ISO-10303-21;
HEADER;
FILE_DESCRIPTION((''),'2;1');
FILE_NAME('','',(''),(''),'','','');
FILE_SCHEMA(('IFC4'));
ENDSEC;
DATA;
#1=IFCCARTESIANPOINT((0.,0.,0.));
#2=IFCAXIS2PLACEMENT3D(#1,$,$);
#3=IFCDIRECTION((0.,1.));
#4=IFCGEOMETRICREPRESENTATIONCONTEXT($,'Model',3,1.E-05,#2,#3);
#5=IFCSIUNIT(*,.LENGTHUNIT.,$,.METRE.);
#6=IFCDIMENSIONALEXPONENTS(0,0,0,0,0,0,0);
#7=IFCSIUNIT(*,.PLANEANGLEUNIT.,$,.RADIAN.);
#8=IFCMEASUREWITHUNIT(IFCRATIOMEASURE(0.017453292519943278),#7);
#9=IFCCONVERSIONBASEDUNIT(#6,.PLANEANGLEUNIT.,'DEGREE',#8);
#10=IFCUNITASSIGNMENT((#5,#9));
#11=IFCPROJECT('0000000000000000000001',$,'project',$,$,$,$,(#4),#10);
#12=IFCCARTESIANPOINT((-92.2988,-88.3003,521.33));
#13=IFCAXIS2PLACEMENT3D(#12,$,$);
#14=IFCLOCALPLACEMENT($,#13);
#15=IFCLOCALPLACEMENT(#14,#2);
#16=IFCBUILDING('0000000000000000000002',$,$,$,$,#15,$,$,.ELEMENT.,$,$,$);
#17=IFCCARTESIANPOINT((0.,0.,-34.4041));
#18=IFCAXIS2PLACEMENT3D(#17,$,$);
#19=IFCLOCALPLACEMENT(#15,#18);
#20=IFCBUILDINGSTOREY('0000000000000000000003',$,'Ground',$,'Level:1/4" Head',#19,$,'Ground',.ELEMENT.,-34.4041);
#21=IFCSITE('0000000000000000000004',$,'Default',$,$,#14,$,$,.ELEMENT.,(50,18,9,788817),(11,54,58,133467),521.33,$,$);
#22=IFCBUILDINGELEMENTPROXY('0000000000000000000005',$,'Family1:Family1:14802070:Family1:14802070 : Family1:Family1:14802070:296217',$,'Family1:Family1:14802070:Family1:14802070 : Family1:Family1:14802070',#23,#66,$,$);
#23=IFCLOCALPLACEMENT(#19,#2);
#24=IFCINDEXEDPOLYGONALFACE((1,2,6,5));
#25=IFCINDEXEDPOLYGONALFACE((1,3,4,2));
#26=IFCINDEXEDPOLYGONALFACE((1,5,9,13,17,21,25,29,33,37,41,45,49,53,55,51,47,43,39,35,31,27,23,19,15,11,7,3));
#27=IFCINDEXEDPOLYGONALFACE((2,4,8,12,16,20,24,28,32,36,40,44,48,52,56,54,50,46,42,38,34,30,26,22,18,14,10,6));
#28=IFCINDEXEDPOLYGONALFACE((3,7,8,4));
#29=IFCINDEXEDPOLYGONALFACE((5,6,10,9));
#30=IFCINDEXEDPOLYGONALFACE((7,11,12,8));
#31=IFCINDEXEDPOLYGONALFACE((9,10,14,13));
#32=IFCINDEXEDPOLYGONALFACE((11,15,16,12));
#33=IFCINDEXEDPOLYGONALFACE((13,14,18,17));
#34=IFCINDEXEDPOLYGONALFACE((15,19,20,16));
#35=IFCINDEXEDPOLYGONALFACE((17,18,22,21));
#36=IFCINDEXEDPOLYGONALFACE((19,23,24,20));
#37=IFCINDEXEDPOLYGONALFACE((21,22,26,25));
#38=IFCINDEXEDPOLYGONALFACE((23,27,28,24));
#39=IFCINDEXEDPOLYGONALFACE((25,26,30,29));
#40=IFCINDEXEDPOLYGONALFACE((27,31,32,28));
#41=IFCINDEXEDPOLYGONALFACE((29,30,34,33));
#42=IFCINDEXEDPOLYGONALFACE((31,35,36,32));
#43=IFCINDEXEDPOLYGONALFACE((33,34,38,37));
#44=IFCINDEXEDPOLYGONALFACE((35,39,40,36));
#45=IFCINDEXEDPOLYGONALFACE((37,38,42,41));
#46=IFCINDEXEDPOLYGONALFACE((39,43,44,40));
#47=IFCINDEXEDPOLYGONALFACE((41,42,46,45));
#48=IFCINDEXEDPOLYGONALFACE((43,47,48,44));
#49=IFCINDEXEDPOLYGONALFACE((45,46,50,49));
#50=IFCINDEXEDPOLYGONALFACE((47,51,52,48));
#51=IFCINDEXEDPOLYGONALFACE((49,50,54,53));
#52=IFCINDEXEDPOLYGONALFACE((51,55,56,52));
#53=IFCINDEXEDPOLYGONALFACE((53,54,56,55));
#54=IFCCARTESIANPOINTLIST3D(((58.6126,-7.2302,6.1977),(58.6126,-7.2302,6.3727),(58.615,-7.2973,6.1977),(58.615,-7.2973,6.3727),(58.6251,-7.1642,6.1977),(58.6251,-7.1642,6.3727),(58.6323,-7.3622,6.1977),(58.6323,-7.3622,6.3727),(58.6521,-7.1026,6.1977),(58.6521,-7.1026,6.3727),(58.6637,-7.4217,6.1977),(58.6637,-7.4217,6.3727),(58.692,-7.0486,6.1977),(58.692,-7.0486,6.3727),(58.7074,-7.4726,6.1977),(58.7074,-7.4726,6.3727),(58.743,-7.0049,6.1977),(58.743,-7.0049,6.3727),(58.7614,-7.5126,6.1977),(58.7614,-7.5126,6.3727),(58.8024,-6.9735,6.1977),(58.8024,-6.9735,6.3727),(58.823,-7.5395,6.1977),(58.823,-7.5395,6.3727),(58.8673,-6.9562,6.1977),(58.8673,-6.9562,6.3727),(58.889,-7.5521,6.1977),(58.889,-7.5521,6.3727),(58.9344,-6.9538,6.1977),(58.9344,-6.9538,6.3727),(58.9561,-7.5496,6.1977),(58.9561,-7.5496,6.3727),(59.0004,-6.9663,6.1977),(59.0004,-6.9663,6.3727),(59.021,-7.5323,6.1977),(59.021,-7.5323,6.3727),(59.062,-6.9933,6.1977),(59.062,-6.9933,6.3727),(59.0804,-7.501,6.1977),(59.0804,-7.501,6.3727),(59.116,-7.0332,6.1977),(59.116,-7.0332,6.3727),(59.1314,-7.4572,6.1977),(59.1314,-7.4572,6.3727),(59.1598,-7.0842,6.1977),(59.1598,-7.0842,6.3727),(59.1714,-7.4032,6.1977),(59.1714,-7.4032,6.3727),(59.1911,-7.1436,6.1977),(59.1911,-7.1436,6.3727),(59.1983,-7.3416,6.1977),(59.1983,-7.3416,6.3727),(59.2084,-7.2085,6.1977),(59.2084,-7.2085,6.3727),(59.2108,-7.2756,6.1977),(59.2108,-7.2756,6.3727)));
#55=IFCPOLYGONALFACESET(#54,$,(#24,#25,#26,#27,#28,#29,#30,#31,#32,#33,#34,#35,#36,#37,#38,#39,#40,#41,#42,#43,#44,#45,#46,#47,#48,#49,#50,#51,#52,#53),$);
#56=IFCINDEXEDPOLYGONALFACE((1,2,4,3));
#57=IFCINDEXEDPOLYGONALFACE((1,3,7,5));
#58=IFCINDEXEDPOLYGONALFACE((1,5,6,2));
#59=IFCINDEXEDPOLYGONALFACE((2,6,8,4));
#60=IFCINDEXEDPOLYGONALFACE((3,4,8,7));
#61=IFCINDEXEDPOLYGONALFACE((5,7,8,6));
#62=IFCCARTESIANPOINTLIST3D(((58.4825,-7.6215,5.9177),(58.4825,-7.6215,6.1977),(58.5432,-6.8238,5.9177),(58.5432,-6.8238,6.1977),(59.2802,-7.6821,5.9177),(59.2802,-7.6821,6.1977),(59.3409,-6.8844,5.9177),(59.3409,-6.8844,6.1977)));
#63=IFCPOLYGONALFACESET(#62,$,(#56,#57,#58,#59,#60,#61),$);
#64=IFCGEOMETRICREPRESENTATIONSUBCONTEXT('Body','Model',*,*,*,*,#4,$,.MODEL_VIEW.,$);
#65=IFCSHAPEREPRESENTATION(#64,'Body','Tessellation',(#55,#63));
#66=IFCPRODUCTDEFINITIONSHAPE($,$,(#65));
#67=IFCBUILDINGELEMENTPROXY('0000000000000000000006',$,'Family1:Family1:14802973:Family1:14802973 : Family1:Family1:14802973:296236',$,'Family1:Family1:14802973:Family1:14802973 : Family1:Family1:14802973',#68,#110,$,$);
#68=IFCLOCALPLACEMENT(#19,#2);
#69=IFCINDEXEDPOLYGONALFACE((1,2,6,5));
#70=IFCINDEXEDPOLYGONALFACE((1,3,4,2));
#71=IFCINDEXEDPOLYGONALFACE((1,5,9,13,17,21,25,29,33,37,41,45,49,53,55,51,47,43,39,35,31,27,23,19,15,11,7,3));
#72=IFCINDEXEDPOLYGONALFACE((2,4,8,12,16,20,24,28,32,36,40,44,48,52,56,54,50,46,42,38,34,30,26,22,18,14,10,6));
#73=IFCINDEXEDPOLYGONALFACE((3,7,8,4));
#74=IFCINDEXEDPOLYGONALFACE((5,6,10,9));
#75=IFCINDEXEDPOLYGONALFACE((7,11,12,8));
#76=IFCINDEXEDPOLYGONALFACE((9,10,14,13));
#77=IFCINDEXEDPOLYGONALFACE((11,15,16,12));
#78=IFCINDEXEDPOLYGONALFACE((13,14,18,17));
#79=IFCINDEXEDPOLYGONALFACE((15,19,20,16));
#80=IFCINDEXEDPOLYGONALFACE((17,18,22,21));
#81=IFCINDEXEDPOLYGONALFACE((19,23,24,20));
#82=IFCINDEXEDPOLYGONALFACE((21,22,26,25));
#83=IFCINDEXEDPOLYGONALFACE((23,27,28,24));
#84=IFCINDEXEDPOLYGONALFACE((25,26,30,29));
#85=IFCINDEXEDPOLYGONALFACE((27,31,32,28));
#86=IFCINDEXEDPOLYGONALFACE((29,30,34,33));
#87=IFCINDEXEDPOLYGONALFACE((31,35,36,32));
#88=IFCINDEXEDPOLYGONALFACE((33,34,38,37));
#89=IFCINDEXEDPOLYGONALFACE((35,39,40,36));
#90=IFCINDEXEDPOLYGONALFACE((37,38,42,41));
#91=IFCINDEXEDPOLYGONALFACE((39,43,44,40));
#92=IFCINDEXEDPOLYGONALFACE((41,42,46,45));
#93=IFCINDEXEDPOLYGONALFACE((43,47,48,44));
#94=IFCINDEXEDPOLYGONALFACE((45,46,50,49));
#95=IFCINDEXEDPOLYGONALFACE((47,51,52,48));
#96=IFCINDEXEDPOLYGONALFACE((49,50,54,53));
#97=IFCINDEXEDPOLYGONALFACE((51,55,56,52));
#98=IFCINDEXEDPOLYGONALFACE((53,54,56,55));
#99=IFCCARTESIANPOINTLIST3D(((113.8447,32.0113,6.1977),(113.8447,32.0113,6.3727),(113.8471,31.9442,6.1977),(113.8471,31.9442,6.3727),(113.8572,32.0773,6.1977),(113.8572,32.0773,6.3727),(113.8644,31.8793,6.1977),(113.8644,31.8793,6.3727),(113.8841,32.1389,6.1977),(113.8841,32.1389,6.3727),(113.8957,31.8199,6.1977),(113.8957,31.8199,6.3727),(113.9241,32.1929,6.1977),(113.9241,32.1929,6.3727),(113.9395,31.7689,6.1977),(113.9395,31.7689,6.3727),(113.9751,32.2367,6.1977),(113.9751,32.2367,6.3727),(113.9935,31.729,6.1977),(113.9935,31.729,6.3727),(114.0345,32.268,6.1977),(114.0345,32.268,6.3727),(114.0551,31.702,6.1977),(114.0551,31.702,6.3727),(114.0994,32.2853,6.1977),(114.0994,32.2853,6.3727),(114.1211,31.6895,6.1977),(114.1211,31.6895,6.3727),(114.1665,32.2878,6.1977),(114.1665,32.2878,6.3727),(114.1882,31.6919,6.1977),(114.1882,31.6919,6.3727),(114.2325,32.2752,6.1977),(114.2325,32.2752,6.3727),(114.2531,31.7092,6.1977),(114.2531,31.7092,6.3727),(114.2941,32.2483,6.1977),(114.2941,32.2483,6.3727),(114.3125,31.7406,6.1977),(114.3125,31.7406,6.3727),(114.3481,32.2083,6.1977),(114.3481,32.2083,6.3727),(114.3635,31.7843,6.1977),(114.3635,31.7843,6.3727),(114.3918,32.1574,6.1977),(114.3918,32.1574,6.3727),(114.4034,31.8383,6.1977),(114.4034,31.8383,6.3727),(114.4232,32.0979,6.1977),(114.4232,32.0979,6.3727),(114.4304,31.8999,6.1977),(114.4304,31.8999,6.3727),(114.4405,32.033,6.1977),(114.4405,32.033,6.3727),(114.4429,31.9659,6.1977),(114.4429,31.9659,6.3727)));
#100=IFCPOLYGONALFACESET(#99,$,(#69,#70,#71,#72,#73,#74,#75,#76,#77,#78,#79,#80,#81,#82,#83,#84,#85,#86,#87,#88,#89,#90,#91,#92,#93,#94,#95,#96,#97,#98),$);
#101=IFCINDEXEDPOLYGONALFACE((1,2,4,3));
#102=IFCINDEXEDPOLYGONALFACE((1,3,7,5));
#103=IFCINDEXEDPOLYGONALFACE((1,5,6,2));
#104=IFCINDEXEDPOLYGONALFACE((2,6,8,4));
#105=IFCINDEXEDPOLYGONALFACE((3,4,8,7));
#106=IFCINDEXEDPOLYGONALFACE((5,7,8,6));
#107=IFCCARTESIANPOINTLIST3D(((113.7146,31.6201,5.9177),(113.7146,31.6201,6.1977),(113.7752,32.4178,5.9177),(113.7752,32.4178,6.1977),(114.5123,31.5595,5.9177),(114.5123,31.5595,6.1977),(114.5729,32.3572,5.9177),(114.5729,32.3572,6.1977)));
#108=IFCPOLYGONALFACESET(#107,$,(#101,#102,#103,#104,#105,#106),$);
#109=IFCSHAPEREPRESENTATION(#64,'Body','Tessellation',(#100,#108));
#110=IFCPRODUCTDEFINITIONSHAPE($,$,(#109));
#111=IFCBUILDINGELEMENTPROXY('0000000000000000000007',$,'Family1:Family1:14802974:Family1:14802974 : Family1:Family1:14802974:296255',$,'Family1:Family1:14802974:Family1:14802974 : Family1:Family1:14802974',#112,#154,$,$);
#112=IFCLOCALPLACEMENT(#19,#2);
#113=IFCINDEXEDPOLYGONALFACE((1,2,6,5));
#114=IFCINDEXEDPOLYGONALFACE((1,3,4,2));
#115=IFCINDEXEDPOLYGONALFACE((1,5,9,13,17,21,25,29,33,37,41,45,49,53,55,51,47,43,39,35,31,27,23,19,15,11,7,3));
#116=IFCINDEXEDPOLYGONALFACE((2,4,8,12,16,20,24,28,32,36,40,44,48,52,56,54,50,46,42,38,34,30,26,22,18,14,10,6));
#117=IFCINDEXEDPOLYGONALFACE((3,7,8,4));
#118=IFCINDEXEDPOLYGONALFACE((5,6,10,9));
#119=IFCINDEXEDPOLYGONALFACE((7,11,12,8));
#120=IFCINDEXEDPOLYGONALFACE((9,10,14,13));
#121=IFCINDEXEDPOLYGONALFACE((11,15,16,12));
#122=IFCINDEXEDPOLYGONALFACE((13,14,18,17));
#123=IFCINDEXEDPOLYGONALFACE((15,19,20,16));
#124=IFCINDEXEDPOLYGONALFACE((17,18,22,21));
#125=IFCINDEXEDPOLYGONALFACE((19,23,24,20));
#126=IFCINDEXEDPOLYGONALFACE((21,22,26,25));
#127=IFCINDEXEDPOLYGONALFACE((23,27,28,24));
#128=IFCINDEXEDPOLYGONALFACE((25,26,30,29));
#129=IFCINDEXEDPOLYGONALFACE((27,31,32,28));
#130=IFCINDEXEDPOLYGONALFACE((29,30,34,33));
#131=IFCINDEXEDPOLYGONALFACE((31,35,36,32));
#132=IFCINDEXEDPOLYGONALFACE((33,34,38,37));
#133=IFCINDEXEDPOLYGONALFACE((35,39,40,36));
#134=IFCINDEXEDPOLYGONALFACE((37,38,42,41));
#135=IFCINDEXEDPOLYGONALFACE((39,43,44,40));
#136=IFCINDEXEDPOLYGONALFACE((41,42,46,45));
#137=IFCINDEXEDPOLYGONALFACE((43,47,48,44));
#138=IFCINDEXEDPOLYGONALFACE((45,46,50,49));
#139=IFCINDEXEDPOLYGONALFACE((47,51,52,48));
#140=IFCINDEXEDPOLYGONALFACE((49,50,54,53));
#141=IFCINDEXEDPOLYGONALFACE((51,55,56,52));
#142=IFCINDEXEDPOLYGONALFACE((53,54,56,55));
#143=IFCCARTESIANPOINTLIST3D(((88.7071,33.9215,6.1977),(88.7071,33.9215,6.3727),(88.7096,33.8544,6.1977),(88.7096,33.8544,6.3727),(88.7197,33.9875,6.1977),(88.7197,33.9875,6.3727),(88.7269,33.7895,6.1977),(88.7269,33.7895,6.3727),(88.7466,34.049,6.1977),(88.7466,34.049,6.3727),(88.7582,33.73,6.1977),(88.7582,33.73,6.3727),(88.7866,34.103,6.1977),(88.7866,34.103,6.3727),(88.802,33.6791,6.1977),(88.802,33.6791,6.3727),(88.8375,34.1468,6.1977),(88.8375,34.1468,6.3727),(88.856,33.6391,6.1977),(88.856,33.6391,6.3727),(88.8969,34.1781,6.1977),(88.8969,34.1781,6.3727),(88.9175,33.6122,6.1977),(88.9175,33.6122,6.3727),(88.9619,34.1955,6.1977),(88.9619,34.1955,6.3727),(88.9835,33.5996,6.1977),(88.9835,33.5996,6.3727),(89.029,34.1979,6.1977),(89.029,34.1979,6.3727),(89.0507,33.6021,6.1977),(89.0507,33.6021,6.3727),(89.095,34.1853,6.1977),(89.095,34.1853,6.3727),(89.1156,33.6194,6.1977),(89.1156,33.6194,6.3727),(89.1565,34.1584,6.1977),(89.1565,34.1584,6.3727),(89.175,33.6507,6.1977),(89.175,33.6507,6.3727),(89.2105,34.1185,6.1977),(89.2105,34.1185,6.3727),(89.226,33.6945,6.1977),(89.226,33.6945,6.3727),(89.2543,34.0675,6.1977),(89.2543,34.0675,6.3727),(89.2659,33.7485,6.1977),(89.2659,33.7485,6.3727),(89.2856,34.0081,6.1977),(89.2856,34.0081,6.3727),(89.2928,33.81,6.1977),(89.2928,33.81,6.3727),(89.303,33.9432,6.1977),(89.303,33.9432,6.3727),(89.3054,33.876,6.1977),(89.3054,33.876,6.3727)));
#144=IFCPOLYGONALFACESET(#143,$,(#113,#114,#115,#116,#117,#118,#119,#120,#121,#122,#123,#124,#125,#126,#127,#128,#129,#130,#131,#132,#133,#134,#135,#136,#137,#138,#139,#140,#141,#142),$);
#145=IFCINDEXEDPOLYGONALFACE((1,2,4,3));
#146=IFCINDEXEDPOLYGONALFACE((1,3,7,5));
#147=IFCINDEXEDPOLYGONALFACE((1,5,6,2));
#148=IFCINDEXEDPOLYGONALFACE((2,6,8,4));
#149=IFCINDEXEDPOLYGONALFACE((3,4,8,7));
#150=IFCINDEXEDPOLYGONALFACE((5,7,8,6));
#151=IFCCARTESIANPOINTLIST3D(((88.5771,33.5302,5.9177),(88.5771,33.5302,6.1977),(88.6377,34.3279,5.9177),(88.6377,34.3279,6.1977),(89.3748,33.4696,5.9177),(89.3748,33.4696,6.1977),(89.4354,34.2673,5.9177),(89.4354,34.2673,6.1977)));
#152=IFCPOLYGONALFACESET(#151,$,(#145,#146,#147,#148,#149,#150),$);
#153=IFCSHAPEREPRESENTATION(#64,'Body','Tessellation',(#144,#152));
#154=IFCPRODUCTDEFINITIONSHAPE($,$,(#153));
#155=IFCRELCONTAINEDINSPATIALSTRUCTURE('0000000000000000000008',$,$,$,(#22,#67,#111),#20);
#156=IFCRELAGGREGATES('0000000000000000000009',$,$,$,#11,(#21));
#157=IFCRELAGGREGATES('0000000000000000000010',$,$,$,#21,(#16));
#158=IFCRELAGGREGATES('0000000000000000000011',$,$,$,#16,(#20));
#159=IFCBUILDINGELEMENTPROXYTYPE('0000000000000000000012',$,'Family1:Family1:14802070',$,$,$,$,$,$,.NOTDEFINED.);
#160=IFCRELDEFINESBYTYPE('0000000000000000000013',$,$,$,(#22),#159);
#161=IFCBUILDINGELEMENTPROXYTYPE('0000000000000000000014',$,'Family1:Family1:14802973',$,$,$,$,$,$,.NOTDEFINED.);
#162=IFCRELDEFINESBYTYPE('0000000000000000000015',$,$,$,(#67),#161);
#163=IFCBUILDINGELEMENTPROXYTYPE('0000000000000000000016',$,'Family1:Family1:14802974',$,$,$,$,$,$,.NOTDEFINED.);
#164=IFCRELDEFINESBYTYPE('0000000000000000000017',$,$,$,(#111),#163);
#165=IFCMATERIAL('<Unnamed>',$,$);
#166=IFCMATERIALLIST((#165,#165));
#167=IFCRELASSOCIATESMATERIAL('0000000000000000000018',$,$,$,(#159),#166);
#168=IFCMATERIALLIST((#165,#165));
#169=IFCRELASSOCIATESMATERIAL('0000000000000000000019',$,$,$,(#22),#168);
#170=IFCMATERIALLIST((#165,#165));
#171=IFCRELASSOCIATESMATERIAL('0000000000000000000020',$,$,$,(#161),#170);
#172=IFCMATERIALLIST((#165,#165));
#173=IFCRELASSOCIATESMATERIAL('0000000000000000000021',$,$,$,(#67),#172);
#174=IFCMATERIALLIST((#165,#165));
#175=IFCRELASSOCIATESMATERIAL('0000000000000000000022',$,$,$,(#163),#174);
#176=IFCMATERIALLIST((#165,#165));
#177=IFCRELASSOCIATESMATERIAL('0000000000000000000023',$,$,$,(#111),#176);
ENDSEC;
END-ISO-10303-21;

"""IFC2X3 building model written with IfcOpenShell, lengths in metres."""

from ifc_helpers import new_model, entity, si_unit, converted_unit, direction, frame, frame_2d, origin, origin_2d_with_axis, place, context, subcontext, project, spatial, rectangle, circle, extrude, source, transform, mapped, material, material_list, type_object, type_shapes, element, save


model = new_model("IFC2X3")

# Units and contexts
model_context = context("Model", 3, precision=1e-05, world=origin(), true_north=direction((0.0, 1.0)))
body_context = subcontext(model_context, "Body", "Model", "MODEL_VIEW")
ifc_project = project(units=[si_unit("LENGTHUNIT", "METRE"), converted_unit("PLANEANGLEUNIT", "DEGREE", entity("IfcRatioMeasure", 0.017453292519943278), si_unit("PLANEANGLEUNIT", "RADIAN"), dimensions=[0, 0, 0, 0, 0, 0, 0])], contexts=[model_context])

# Site, building, storey
site_placement = place(None, frame((-92.2988, -88.3003, 521.33)))
site = spatial("IfcSite", under=ifc_project, at=site_placement, Name="Default", CompositionType="ELEMENT", RefLatitude=(50, 18, 9, 788817), RefLongitude=(11, 54, 58, 133467), RefElevation=521.33)
building_placement = place(site_placement, origin())
building = spatial("IfcBuilding", under=site, at=building_placement, CompositionType="ELEMENT")
storey_placement = place(building_placement, frame((0.0, 0.0, -34.4041)))
storey = spatial("IfcBuildingStorey", under=building, at=storey_placement, Name="Ground", ObjectType="Level:1/4\" Head", LongName="Ground", CompositionType="ELEMENT", Elevation=-34.4041)

# Building element proxies
ifc_material_1 = material(Name="<Unnamed>")
ifc_material_list_1 = material_list([ifc_material_1, ifc_material_1])
ifc_material_list_2 = material_list([ifc_material_1, ifc_material_1])
building_element_proxy_type_1 = type_object("IfcBuildingElementProxyType", Name="Family1:Family1:14802070", PredefinedType="NOTDEFINED", material=ifc_material_list_2)
shared_shape_1 = source(origin(), body_context, "Body", "SweptSolid", [
    extrude(circle(Radius=0.3, at=frame_2d((0.0, 0.0), x_axis=(1.0, 0.0))), frame((58.9117, -7.2529, -28.2064), z_axis=(0.0, 0.0, 1.0), x_axis=(0.997125, -0.07577, 0.0)), (0.0, 0.0, 1.0), 0.175),
    extrude(rectangle(XDim=0.8, YDim=0.8, at=frame_2d((0.0, 0.0), x_axis=(1.0, 0.0))), frame((58.9117, -7.2529, -28.4864), z_axis=(0.0, 0.0, 1.0), x_axis=(-0.07577, -0.997125, 0.0)), (0.0, 0.0, 1.0), 0.28),
])
type_shapes(building_element_proxy_type_1, [shared_shape_1])
proxy_1_placement = place(storey_placement, frame((0.0, 0.0, 34.4041)))
element("IfcBuildingElementProxy", 1, at=proxy_1_placement, inside=storey, type_object=building_element_proxy_type_1, material=ifc_material_list_1, Name="Family1:Family1:14802070:Family1:14802070 : Family1:Family1:14802070:296217", ObjectType="Family1:Family1:14802070:Family1:14802070 : Family1:Family1:14802070", context=body_context, shape_type="MappedRepresentation", body=[
    mapped(shared_shape_1, transform((0.0, 0.0, 0.0), scale=1.0)),
])
ifc_material_list_3 = material_list([ifc_material_1, ifc_material_1])
ifc_material_list_4 = material_list([ifc_material_1, ifc_material_1])
building_element_proxy_type_2 = type_object("IfcBuildingElementProxyType", Name="Family1:Family1:14802973", PredefinedType="NOTDEFINED", material=ifc_material_list_4)
shared_shape_2 = source(origin(), body_context, "Body", "SweptSolid", [
    extrude(circle(Radius=0.3, at=frame_2d((0.0, 0.0), x_axis=(1.0, 0.0))), frame((114.1438, 31.9886, -28.2064), z_axis=(0.0, 0.0, 1.0), x_axis=(0.997125, -0.07577, 0.0)), (0.0, 0.0, 1.0), 0.175),
    extrude(rectangle(XDim=0.8, YDim=0.8, at=frame_2d((0.0, 0.0), x_axis=(1.0, 0.0))), frame((114.1438, 31.9886, -28.4864), z_axis=(0.0, 0.0, 1.0), x_axis=(-0.07577, -0.997125, 0.0)), (0.0, 0.0, 1.0), 0.28),
])
type_shapes(building_element_proxy_type_2, [shared_shape_2])
proxy_2_placement = place(storey_placement, frame((0.0, 0.0, 34.4041)))
element("IfcBuildingElementProxy", 2, at=proxy_2_placement, inside=storey, type_object=building_element_proxy_type_2, material=ifc_material_list_3, Name="Family1:Family1:14802973:Family1:14802973 : Family1:Family1:14802973:296236", ObjectType="Family1:Family1:14802973:Family1:14802973 : Family1:Family1:14802973", context=body_context, shape_type="MappedRepresentation", body=[
    mapped(shared_shape_2, transform((0.0, 0.0, 0.0), scale=1.0)),
])
ifc_material_list_5 = material_list([ifc_material_1, ifc_material_1])
ifc_material_list_6 = material_list([ifc_material_1, ifc_material_1])
building_element_proxy_type_3 = type_object("IfcBuildingElementProxyType", Name="Family1:Family1:14802974", PredefinedType="NOTDEFINED", material=ifc_material_list_6)
shared_shape_3 = source(origin(), body_context, "Body", "SweptSolid", [
    extrude(circle(Radius=0.3, at=frame_2d((0.0, 0.0), x_axis=(1.0, 0.0))), frame((89.0063, 33.8988, -28.2064), z_axis=(0.0, 0.0, 1.0), x_axis=(0.997125, -0.07577, 0.0)), (0.0, 0.0, 1.0), 0.175),
    extrude(rectangle(XDim=0.8, YDim=0.8, at=origin_2d_with_axis()), frame((89.0063, 33.8988, -28.4864), z_axis=(0.0, 0.0, 1.0), x_axis=(-0.07577, -0.997125, 0.0)), (0.0, 0.0, 1.0), 0.28),
])
type_shapes(building_element_proxy_type_3, [shared_shape_3])
proxy_3_placement = place(storey_placement, frame((0.0, 0.0, 34.4041)))
element("IfcBuildingElementProxy", 3, at=proxy_3_placement, inside=storey, type_object=building_element_proxy_type_3, material=ifc_material_list_5, Name="Family1:Family1:14802974:Family1:14802974 : Family1:Family1:14802974:296255", ObjectType="Family1:Family1:14802974:Family1:14802974 : Family1:Family1:14802974", context=body_context, shape_type="MappedRepresentation", body=[
    mapped(shared_shape_3, transform((0.0, 0.0, 0.0), scale=1.0)),
])

save(model, "model.ifc")
